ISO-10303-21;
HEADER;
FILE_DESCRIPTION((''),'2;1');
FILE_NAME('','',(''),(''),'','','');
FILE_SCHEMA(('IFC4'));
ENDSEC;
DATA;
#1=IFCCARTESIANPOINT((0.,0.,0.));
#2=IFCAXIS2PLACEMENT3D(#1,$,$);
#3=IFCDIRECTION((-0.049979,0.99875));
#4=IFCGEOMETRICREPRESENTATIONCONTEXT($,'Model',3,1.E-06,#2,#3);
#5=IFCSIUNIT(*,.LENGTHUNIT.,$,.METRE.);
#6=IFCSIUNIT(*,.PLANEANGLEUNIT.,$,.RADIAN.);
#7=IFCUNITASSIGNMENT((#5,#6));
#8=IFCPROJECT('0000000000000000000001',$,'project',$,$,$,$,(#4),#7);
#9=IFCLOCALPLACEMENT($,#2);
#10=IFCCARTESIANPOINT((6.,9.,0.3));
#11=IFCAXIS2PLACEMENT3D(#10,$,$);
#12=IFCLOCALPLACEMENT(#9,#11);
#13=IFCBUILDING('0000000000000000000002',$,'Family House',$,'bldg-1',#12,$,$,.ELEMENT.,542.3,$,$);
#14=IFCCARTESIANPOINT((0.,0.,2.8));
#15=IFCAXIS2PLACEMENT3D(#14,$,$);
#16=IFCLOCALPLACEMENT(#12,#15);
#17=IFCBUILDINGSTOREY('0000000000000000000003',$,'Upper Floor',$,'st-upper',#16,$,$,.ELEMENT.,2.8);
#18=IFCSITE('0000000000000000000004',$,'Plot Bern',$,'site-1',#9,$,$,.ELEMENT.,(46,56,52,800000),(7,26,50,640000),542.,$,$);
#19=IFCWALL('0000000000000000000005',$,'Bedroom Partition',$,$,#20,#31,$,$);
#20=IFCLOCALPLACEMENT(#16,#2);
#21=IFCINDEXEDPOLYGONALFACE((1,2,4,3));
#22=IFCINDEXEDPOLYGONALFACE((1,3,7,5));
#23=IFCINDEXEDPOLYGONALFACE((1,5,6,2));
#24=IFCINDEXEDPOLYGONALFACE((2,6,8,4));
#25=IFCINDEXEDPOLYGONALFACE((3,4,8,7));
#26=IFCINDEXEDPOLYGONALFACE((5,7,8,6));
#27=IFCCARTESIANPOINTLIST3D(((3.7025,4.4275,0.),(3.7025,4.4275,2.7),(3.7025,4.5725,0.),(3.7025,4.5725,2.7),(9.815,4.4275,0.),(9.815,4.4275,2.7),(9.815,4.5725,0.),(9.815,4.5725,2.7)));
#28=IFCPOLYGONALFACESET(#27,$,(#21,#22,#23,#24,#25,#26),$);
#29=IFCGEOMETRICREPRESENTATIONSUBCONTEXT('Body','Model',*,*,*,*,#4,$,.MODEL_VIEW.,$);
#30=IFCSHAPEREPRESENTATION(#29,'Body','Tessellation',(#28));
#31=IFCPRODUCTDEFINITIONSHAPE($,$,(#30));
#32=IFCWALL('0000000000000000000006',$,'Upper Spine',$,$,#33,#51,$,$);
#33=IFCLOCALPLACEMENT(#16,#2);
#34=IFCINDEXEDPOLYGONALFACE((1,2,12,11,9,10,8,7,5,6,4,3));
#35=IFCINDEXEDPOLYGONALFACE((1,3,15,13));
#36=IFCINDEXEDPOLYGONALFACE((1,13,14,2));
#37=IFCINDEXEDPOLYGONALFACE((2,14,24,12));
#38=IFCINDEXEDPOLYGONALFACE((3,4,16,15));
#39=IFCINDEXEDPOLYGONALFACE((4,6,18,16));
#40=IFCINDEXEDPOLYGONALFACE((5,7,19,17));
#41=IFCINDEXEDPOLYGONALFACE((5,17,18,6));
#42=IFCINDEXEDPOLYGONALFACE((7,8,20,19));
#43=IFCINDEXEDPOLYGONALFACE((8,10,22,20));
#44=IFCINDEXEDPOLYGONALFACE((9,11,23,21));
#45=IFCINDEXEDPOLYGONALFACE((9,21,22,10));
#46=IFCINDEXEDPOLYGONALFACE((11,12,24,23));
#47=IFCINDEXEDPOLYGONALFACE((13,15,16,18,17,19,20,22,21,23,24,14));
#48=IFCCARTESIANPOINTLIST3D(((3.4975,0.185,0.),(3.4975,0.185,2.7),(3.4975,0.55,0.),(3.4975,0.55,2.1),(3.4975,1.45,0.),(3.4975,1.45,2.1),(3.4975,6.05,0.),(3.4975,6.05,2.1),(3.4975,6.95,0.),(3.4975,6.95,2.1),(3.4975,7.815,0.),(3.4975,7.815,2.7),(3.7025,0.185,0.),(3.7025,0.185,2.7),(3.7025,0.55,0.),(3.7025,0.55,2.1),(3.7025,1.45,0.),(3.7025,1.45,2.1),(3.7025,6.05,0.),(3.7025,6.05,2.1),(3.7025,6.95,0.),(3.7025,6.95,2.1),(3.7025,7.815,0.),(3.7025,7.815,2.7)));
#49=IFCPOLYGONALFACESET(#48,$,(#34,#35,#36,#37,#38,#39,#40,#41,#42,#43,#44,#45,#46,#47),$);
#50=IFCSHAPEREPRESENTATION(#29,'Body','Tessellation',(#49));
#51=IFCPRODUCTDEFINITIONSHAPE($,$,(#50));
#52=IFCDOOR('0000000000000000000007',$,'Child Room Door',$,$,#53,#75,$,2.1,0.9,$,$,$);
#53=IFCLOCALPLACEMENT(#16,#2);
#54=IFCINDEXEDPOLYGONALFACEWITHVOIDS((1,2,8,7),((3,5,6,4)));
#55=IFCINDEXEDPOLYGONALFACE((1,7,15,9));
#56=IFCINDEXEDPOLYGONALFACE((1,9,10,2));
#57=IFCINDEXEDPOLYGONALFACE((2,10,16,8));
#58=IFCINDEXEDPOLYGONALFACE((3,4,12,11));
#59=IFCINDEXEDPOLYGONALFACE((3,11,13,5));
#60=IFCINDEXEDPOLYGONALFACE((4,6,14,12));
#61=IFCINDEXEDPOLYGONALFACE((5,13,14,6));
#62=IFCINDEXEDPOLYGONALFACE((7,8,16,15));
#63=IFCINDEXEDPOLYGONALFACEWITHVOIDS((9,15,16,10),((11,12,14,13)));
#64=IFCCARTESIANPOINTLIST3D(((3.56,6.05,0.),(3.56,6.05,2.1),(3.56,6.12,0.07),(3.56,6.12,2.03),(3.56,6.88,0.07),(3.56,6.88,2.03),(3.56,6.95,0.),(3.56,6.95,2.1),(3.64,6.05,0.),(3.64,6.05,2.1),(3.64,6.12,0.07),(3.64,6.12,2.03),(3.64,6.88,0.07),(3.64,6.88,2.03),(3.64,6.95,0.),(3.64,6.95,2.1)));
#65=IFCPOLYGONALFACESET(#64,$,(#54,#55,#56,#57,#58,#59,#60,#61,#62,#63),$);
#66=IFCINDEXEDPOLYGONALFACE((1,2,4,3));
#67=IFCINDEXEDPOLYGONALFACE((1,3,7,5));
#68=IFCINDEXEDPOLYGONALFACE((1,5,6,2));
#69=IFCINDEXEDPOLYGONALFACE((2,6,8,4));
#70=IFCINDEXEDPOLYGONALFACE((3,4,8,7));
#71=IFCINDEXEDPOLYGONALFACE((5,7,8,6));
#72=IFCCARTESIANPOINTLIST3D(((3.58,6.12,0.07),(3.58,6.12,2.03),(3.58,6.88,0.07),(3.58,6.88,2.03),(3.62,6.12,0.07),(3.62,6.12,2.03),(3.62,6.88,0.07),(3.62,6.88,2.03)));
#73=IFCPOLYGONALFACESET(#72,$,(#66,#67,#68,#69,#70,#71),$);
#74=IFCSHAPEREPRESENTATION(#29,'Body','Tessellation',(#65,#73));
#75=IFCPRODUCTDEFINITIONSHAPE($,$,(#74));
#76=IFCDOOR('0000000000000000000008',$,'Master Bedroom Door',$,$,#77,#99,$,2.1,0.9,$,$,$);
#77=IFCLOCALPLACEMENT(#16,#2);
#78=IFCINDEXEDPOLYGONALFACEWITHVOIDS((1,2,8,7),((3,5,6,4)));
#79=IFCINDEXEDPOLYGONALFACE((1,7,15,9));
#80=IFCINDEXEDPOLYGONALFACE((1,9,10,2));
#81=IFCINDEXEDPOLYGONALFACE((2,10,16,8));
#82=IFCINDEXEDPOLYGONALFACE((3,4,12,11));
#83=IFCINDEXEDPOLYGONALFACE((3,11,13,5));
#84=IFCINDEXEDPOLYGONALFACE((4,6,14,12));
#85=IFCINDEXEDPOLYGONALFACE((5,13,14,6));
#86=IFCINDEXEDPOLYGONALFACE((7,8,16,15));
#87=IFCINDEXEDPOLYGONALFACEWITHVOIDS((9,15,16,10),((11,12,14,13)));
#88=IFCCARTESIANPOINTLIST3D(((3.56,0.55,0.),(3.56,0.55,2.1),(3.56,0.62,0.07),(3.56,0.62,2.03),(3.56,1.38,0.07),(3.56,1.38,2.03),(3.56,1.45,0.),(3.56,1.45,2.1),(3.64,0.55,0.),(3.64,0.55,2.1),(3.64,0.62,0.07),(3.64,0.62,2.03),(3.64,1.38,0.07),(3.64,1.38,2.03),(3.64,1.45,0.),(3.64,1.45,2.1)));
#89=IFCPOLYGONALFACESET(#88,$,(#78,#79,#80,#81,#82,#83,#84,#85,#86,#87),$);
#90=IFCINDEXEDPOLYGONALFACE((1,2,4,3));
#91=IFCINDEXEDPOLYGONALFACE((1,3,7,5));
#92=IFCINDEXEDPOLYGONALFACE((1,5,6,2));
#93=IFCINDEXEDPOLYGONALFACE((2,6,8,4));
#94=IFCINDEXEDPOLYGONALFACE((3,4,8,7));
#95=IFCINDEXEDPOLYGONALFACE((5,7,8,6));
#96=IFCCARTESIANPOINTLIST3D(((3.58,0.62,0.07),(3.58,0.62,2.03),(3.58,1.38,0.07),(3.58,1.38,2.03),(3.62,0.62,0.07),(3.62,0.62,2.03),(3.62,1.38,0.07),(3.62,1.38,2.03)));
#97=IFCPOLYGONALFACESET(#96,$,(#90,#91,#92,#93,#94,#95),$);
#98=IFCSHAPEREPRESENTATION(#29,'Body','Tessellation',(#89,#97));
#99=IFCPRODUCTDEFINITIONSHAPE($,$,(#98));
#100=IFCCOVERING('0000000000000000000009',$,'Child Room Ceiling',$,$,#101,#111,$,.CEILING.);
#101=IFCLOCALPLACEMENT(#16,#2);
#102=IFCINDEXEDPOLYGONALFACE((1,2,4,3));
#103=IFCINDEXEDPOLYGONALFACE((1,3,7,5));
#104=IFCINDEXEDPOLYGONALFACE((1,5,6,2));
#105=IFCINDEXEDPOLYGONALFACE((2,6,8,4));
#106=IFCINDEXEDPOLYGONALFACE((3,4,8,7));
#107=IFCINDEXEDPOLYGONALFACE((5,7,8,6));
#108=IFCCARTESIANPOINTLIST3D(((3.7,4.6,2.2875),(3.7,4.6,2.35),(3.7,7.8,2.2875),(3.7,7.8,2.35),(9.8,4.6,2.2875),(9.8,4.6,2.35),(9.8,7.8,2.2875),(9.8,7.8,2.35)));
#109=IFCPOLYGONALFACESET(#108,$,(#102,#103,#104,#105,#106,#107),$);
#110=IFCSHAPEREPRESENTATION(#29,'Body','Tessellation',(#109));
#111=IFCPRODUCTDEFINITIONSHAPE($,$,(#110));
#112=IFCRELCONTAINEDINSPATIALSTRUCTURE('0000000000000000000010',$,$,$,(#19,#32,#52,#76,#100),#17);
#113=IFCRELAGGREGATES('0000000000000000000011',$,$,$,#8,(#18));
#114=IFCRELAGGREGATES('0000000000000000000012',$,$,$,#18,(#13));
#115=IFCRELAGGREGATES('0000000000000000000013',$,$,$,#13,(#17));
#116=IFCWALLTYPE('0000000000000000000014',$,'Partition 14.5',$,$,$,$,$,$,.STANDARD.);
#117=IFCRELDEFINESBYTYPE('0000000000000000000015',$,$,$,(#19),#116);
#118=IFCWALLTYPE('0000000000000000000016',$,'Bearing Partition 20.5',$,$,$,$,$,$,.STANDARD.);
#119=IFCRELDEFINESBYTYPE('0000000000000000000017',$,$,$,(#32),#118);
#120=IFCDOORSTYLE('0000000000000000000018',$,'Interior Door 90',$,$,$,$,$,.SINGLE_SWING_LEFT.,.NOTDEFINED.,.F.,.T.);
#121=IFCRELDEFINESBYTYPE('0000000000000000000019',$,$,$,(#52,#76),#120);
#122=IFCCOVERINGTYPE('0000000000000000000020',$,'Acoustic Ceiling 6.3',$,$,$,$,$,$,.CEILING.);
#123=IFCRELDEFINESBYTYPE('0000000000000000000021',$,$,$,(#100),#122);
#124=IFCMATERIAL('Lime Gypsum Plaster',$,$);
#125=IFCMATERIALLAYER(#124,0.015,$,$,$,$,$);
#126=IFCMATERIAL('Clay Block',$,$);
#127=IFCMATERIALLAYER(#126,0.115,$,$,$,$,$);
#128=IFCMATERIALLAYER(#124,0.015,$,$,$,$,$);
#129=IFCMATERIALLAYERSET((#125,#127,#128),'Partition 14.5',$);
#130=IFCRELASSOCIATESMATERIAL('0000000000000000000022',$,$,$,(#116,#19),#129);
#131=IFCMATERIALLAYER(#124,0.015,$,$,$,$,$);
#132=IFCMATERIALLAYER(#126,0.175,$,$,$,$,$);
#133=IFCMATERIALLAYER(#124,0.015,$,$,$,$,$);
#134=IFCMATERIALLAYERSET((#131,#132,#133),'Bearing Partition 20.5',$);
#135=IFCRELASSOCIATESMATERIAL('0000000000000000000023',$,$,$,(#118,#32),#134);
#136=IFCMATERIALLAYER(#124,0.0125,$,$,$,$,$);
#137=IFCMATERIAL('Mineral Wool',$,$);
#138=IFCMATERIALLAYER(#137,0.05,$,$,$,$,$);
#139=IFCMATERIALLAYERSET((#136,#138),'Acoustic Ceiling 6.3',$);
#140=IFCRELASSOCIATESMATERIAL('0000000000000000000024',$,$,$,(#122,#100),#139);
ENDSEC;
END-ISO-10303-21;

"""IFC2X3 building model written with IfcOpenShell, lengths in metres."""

from ifc_helpers import new_model, si_unit, direction, frame, frame_2d, origin, origin_2d, place, context, subcontext, project, spatial, polyline, rectangle, outline, extrude, material, layer, layer_set, layer_usage, type_object, element, fill, save


model = new_model("IFC2X3")

# Units and contexts
model_context = context("Model", 3, precision=1e-06, world=origin(), true_north=direction((-0.049979, 0.99875)))
body_context = subcontext(model_context, "Body", "Model", "MODEL_VIEW")
ifc_project = project(units=[si_unit("LENGTHUNIT", "METRE"), si_unit("PLANEANGLEUNIT", "RADIAN")], contexts=[model_context])

# Site, building, storey
site_placement = place(None, origin())
site = spatial("IfcSite", under=ifc_project, at=site_placement, Name="Plot Bern", ObjectType="site-1", CompositionType="ELEMENT", RefLatitude=(46, 56, 52, 800000), RefLongitude=(7, 26, 50, 640000), RefElevation=542.0)
building_placement = place(site_placement, frame((6.0, 9.0, 0.3)))
building = spatial("IfcBuilding", under=site, at=building_placement, Name="Family House", ObjectType="bldg-1", CompositionType="ELEMENT", ElevationOfRefHeight=542.3)
storey_placement = place(building_placement, frame((0.0, 0.0, 2.8)))
storey = spatial("IfcBuildingStorey", under=building, at=storey_placement, Name="Upper Floor", ObjectType="st-upper", CompositionType="ELEMENT", Elevation=2.8)

# Shared definitions
ifc_material_1 = material(Name="Mineral Wool")

# Shared definitions
ifc_material_2 = material(Name="Lime Gypsum Plaster")
ifc_material_3 = material(Name="Clay Block")

# Shared definitions
ifc_layer_1 = layer(ifc_material_2, 0.015)
ifc_layer_2 = layer(ifc_material_3, 0.115)
ifc_layer_3 = layer(ifc_material_2, 0.015)
ifc_layer_set_1 = layer_set([ifc_layer_1, ifc_layer_2, ifc_layer_3], Name="Partition 14.5")
wall_type_1 = type_object("IfcWallType", Name="Partition 14.5", PredefinedType="STANDARD", material=ifc_layer_set_1)

# Wall
ifc_layer_usage_1 = layer_usage(ifc_layer_set_1, "AXIS2", "NEGATIVE", 0.0725)
wall_1_placement = place(storey_placement, origin())
element("IfcWall", 1, at=wall_1_placement, inside=storey, type_object=wall_type_1, material=ifc_layer_usage_1, Name="Bedroom Partition", context=body_context, shape_type="SweptSolid", body=[
    extrude(outline(polyline([(3.7025, 4.4275), (9.815, 4.4275), (9.815, 4.5725), (3.7025, 4.5725), (3.7025, 4.4275)])), origin(), (0.0, 0.0, 1.0), 2.7),
])

# Wall, openings, doors
ifc_layer_4 = layer(ifc_material_2, 0.015)
ifc_layer_5 = layer(ifc_material_3, 0.175)
ifc_layer_6 = layer(ifc_material_2, 0.015)
ifc_layer_set_2 = layer_set([ifc_layer_4, ifc_layer_5, ifc_layer_6], Name="Bearing Partition 20.5")
ifc_layer_usage_2 = layer_usage(ifc_layer_set_2, "AXIS2", "NEGATIVE", 0.1025)
wall_type_2 = type_object("IfcWallType", Name="Bearing Partition 20.5", PredefinedType="STANDARD", material=ifc_layer_set_2)
wall_2_placement = place(storey_placement, origin())
wall_2 = element("IfcWall", 2, at=wall_2_placement, inside=storey, type_object=wall_type_2, material=ifc_layer_usage_2, Name="Upper Spine", context=body_context, shape_type="SweptSolid", body=[
    extrude(outline(polyline([(3.7025, 0.185), (3.7025, 7.815), (3.4975, 7.815), (3.4975, 0.185), (3.7025, 0.185)])), origin(), (0.0, 0.0, 1.0), 2.7),
])
opening_1_placement = place(wall_2_placement, frame((3.6, 6.5, 0.0), z_axis=(0.0, 0.0, 1.0), x_axis=(0.0, 1.0, 0.0)))
opening_1 = element("IfcOpeningElement", 3, at=opening_1_placement, cuts=wall_2, context=body_context, shape_type="SweptSolid", body=[
    extrude(rectangle(XDim=0.9, YDim=0.205, at=origin_2d()), origin(), (0.0, 0.0, 1.0), 2.1),
])
opening_2_placement = place(wall_2_placement, frame((3.6, 1.0, 0.0), z_axis=(0.0, 0.0, 1.0), x_axis=(0.0, 1.0, 0.0)))
opening_2 = element("IfcOpeningElement", 4, at=opening_2_placement, cuts=wall_2, context=body_context, shape_type="SweptSolid", body=[
    extrude(rectangle(XDim=0.9, YDim=0.205, at=origin_2d()), origin(), (0.0, 0.0, 1.0), 2.1),
])
door_style_1 = type_object("IfcDoorStyle", Name="Interior Door 90", ConstructionType="NOTDEFINED", OperationType="SINGLE_SWING_LEFT", ParameterTakesPrecedence=False, Sizeable=True)
door_1_placement = place(opening_1_placement, frame((0.0, 0.0, 0.0), z_axis=(0.0, -1.0, 0.0), x_axis=(1.0, 0.0, 0.0)))
door_1 = element("IfcDoor", 5, at=door_1_placement, inside=storey, type_object=door_style_1, Name="Child Room Door", OverallHeight=2.1, OverallWidth=0.9, context=body_context, shape_type="SweptSolid", body=[
    extrude(outline(polyline([(-0.45, 0.0), (0.45, 0.0), (0.45, 2.1), (-0.45, 2.1), (-0.45, 0.0)]), holes=[polyline([(-0.38, 0.07), (0.38, 0.07), (0.38, 2.03), (-0.38, 2.03), (-0.38, 0.07)])]), frame((0.0, 0.0, -0.04)), (0.0, 0.0, 1.0), 0.08),
    extrude(rectangle(XDim=0.76, YDim=1.96, at=frame_2d((0.0, 1.05))), frame((0.0, 0.0, -0.02)), (0.0, 0.0, 1.0), 0.04),
])
fill(opening_1, door_1)
door_2_placement = place(opening_2_placement, frame((0.0, 0.0, 0.0), z_axis=(0.0, -1.0, 0.0), x_axis=(1.0, 0.0, 0.0)))
door_2 = element("IfcDoor", 6, at=door_2_placement, inside=storey, type_object=door_style_1, Name="Master Bedroom Door", OverallHeight=2.1, OverallWidth=0.9, context=body_context, shape_type="SweptSolid", body=[
    extrude(outline(polyline([(-0.45, 0.0), (0.45, 0.0), (0.45, 2.1), (-0.45, 2.1), (-0.45, 0.0)]), holes=[polyline([(-0.38, 0.07), (0.38, 0.07), (0.38, 2.03), (-0.38, 2.03), (-0.38, 0.07)])]), frame((0.0, 0.0, -0.04)), (0.0, 0.0, 1.0), 0.08),
    extrude(rectangle(XDim=0.76, YDim=1.96, at=frame_2d((0.0, 1.05))), frame((0.0, 0.0, -0.02)), (0.0, 0.0, 1.0), 0.04),
])
fill(opening_2, door_2)

# Covering
ifc_layer_7 = layer(ifc_material_2, 0.0125)
ifc_layer_8 = layer(ifc_material_1, 0.05)
ifc_layer_set_3 = layer_set([ifc_layer_7, ifc_layer_8], Name="Acoustic Ceiling 6.3")
ifc_layer_usage_3 = layer_usage(ifc_layer_set_3, "AXIS3", "NEGATIVE", 0.0625)
covering_type = type_object("IfcCoveringType", Name="Acoustic Ceiling 6.3", PredefinedType="CEILING", material=ifc_layer_set_3)
covering_placement = place(storey_placement, frame((0.0, 0.0, 2.2875)))
element("IfcCovering", 7, at=covering_placement, inside=storey, type_object=covering_type, material=ifc_layer_usage_3, Name="Child Room Ceiling", PredefinedType="CEILING", context=body_context, shape_type="SweptSolid", body=[
    extrude(outline(polyline([(3.7, 4.6), (9.8, 4.6), (9.8, 7.8), (3.7, 7.8), (3.7, 4.6)])), origin(), (0.0, 0.0, 1.0), 0.0625),
])

save(model, "model.ifc")
